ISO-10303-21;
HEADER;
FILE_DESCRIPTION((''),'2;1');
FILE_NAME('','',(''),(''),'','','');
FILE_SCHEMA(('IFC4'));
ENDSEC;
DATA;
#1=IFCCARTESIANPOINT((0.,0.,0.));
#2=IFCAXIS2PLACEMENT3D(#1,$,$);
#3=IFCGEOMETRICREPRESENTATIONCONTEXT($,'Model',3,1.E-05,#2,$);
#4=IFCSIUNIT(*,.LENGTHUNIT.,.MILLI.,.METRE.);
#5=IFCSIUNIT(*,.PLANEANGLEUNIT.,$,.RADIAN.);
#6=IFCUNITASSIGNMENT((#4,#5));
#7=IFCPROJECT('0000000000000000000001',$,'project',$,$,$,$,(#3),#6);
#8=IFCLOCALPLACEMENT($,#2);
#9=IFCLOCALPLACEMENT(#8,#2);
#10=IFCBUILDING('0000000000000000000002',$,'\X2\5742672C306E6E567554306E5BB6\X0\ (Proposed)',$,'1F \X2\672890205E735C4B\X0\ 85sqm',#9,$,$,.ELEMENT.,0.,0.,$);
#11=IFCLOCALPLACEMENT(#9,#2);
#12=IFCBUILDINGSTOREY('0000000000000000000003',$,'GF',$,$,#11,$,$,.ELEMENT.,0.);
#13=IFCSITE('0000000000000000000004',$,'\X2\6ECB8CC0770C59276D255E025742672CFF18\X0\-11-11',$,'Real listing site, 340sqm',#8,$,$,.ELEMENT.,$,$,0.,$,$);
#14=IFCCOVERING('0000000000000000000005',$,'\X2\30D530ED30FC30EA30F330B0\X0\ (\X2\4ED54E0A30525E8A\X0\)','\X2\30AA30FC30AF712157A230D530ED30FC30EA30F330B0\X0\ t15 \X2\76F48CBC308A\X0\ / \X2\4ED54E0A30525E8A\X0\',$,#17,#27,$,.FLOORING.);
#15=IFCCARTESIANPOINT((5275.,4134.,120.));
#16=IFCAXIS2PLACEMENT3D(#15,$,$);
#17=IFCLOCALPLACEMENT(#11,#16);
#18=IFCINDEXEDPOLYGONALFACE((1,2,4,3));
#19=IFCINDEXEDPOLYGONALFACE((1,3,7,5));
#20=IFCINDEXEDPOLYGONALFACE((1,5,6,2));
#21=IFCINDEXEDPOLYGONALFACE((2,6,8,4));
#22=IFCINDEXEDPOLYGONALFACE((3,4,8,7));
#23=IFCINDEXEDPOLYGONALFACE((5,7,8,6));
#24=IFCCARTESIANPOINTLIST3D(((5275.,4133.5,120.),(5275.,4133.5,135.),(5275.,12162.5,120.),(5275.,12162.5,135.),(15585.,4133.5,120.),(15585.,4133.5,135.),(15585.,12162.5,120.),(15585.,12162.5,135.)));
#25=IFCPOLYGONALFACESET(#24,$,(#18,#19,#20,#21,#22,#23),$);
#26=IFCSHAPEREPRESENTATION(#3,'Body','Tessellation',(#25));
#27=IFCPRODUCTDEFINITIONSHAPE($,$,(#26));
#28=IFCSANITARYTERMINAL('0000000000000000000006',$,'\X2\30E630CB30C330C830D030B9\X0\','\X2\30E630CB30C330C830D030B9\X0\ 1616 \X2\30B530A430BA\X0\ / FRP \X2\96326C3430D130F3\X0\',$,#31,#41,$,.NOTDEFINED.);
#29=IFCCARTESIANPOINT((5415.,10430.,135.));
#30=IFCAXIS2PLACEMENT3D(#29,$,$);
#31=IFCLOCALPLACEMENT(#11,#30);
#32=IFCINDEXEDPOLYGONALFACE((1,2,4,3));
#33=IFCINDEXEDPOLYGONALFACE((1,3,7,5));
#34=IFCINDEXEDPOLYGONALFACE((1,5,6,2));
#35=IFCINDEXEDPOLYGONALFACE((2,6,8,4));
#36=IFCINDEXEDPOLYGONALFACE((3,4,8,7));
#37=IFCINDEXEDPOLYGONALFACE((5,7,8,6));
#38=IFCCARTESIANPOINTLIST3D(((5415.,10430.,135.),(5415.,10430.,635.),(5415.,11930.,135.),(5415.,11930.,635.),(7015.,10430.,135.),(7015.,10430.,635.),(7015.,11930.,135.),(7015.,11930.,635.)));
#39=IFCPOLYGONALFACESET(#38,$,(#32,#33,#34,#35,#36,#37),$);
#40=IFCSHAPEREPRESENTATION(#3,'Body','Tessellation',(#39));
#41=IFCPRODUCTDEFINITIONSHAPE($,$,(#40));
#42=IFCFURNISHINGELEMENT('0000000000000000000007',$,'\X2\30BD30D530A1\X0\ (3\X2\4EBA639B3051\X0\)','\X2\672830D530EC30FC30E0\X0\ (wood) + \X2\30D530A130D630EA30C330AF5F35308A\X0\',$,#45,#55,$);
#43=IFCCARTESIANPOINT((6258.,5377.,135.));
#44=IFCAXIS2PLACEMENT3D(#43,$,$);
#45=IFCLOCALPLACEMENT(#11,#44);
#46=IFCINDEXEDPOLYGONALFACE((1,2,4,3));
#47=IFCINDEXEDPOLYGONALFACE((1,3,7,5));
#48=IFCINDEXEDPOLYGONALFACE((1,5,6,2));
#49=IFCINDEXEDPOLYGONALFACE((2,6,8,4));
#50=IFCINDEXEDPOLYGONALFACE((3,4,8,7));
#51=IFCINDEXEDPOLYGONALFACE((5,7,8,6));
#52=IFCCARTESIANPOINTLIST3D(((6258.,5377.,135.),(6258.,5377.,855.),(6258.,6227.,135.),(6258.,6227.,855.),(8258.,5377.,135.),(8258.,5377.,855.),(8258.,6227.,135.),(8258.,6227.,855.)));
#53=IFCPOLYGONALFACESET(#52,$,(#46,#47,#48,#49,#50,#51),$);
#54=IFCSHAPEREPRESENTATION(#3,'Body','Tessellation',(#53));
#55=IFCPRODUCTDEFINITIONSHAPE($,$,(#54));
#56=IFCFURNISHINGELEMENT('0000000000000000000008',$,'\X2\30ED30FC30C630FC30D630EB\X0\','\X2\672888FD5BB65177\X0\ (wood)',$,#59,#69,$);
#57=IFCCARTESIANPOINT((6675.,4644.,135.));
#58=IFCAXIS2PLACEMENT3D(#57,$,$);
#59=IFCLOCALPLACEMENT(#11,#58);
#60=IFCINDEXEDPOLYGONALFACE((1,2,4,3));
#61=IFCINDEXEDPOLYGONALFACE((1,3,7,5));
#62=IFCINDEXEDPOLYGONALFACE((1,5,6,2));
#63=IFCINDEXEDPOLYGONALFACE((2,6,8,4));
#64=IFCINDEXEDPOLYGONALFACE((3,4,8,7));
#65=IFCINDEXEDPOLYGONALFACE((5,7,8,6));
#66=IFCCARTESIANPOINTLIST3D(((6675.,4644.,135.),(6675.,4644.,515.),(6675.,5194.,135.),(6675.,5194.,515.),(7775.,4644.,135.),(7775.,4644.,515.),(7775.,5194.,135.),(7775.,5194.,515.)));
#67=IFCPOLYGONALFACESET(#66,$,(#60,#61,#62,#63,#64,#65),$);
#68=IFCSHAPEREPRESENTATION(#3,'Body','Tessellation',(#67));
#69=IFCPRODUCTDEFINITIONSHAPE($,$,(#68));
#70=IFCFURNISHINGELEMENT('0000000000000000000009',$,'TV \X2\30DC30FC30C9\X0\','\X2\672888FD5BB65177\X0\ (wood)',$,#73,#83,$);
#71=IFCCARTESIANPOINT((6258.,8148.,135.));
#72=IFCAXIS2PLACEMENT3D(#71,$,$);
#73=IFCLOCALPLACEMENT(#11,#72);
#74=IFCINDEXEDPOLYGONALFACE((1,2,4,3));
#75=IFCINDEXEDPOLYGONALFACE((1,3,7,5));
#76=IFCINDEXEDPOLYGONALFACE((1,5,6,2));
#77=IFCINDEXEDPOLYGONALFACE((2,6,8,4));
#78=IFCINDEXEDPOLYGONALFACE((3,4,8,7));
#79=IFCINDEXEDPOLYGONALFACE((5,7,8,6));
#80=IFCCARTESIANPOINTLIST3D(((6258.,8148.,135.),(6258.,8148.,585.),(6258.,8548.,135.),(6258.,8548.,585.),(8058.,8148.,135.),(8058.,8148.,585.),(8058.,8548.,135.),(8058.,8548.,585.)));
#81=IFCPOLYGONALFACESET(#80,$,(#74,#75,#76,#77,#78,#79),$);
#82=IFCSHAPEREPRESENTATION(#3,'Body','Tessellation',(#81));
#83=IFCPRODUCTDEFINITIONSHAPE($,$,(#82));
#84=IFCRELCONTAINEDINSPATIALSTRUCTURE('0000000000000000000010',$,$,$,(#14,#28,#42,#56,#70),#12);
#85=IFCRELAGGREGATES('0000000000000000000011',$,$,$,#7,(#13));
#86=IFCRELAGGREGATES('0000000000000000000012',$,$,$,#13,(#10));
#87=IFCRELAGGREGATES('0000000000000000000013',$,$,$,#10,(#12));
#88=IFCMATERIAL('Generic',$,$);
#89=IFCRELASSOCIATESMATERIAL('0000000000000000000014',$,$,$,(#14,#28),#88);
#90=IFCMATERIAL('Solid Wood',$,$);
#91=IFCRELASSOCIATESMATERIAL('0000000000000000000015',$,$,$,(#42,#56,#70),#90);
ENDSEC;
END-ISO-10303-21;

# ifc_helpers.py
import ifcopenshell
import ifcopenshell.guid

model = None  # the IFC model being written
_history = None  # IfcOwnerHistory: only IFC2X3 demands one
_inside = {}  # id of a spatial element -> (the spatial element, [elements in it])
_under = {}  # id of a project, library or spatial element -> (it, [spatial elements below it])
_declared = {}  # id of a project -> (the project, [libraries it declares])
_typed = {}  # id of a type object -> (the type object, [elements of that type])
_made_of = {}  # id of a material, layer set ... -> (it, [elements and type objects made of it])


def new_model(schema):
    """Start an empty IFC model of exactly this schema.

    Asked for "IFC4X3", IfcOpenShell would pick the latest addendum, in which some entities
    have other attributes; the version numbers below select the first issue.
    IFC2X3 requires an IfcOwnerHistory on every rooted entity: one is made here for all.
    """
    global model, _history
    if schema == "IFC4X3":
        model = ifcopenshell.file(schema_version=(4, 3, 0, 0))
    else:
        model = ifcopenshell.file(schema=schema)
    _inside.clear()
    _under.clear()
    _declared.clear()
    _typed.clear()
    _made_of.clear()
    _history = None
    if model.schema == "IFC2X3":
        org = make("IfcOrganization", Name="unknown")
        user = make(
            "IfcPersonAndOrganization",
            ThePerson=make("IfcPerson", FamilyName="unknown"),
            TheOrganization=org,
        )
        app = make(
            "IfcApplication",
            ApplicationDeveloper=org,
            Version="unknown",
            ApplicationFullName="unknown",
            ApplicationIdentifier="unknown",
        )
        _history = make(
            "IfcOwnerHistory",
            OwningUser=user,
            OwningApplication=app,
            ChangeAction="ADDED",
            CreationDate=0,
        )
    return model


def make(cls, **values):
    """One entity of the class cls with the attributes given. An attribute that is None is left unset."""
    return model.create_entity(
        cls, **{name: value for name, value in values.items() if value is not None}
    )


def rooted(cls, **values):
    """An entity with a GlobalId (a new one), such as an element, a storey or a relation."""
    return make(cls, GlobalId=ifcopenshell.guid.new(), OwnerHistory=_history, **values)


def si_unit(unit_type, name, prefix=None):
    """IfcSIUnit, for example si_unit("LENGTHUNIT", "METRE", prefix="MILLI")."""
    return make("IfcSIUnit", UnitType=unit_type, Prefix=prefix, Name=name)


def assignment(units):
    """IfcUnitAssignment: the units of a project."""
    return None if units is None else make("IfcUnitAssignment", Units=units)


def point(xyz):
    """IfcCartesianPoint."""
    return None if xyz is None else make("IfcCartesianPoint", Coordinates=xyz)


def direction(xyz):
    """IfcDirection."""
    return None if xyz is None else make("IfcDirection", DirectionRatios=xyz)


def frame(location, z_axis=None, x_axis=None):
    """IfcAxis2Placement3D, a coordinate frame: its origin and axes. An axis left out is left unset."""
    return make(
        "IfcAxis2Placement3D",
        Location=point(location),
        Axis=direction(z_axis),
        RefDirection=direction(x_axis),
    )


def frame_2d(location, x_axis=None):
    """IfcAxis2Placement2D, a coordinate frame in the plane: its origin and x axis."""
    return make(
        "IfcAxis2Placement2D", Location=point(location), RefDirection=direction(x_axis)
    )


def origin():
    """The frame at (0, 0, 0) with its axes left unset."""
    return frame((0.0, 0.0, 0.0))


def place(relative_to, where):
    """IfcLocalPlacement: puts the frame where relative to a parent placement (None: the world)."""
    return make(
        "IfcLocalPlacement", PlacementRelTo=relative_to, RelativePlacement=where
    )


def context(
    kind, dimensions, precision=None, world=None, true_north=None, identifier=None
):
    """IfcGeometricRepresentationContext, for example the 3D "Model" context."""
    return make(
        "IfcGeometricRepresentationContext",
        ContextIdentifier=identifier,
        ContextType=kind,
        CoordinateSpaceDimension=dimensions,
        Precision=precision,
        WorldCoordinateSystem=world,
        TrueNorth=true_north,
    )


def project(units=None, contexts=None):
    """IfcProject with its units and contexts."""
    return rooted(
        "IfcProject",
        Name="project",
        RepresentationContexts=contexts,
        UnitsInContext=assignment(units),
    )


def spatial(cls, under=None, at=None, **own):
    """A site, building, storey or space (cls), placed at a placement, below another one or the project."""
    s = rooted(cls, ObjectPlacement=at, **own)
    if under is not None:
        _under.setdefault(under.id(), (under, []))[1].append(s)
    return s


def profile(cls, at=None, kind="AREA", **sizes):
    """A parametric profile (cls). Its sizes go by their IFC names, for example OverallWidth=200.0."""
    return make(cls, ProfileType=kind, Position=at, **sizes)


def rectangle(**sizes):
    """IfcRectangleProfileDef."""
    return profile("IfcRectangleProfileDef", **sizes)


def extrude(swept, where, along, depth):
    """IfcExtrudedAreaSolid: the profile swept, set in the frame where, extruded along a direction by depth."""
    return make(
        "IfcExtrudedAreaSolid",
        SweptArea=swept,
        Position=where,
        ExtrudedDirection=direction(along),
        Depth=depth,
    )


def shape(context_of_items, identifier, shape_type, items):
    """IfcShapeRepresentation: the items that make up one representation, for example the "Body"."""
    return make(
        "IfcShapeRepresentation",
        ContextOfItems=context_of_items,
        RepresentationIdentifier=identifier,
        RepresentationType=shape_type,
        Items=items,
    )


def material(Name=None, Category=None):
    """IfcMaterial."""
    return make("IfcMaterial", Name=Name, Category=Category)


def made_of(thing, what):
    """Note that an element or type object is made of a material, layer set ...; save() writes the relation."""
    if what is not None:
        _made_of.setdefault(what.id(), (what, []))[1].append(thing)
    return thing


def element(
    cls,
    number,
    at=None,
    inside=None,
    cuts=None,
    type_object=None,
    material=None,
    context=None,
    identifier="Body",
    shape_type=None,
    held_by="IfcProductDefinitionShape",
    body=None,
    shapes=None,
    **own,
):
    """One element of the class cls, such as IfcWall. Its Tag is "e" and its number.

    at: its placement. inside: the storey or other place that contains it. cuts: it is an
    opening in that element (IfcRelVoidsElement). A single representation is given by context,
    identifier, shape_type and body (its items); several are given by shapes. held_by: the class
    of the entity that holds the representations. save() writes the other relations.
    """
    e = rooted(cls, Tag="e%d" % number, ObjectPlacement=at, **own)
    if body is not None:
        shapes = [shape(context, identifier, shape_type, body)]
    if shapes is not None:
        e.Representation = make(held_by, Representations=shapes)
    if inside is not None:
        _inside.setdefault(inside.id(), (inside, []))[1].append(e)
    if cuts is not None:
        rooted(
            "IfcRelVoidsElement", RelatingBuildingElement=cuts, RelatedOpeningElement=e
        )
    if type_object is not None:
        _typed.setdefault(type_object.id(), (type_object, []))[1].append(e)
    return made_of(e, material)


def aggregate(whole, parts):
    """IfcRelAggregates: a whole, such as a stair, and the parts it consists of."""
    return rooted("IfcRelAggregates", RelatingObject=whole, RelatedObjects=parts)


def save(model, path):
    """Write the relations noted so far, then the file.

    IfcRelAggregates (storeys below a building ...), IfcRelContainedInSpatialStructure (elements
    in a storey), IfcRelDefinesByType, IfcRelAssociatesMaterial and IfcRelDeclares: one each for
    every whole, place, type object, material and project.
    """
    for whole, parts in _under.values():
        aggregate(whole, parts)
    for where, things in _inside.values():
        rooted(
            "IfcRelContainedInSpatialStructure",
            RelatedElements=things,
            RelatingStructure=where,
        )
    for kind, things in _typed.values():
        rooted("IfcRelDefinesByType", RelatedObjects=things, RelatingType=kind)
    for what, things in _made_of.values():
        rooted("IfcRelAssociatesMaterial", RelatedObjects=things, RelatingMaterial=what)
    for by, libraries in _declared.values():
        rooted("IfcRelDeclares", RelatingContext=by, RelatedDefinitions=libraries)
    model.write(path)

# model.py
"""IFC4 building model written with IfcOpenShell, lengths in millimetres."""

from ifc_helpers import new_model, si_unit, frame, frame_2d, origin, place, context, project, spatial, rectangle, extrude, material, element, save


model = new_model("IFC4")

# Units and contexts
model_context = context("Model", 3, precision=1e-05, world=origin())
ifc_project = project(units=[si_unit("LENGTHUNIT", "METRE", prefix="MILLI"), si_unit("PLANEANGLEUNIT", "RADIAN")], contexts=[model_context])

# Site, building, storey
site_placement = place(None, origin())
site = spatial("IfcSite", under=ifc_project, at=site_placement, Name="滋賀県大津市坂本８-11-11", ObjectType="Real listing site, 340sqm", CompositionType="ELEMENT", RefElevation=0.0)
building_placement = place(site_placement, origin())
building = spatial("IfcBuilding", under=site, at=building_placement, Name="坂本の湖畔の家 (Proposed)", ObjectType="1F 木造平屋 85sqm", CompositionType="ELEMENT", ElevationOfRefHeight=0.0, ElevationOfTerrain=0.0)
storey_placement = place(building_placement, origin())
storey = spatial("IfcBuildingStorey", under=building, at=storey_placement, Name="GF", CompositionType="ELEMENT", Elevation=0.0)

# Shared definitions
ifc_material_1 = material(Name="Solid Wood")

# Covering
ifc_material_2 = material(Name="Generic")
covering_placement = place(storey_placement, frame((5275.0, 4134.0, 120.0)))
element("IfcCovering", 1, at=covering_placement, inside=storey, material=ifc_material_2, Name="フローリング (仕上げ床)", Description="オーク無垢フローリング t15 直貼り / 仕上げ床", PredefinedType="FLOORING", context=model_context, shape_type="SweptSolid", body=[
    extrude(rectangle(XDim=10310.0, YDim=8029.0, at=frame_2d((5155.0, 4014.0))), frame((5275.0, 4134.0, 120.0)), (0.0, 0.0, 1.0), 15.0),
])

# Sanitary terminal
sanitary_terminal_placement = place(storey_placement, frame((5415.0, 10430.0, 135.0)))
element("IfcSanitaryTerminal", 2, at=sanitary_terminal_placement, inside=storey, material=ifc_material_2, Name="ユニットバス", Description="ユニットバス 1616 サイズ / FRP 防水パン", PredefinedType="NOTDEFINED", context=model_context, shape_type="SweptSolid", body=[
    extrude(rectangle(XDim=1600.0, YDim=1500.0, at=frame_2d((800.0, 750.0))), frame((5415.0, 10430.0, 135.0)), (0.0, 0.0, 1.0), 500.0),
])

# Furnishing elements
furnishing_1_placement = place(storey_placement, frame((6258.0, 5377.0, 135.0)))
element("IfcFurnishingElement", 3, at=furnishing_1_placement, inside=storey, material=ifc_material_1, Name="ソファ (3人掛け)", Description="木フレーム (wood) + ファブリック張り", context=model_context, shape_type="SweptSolid", body=[
    extrude(rectangle(XDim=2000.0, YDim=850.0, at=frame_2d((1000.0, 425.0))), frame((6258.0, 5377.0, 135.0)), (0.0, 0.0, 1.0), 720.0),
])
furnishing_2_placement = place(storey_placement, frame((6675.0, 4644.0, 135.0)))
element("IfcFurnishingElement", 4, at=furnishing_2_placement, inside=storey, material=ifc_material_1, Name="ローテーブル", Description="木製家具 (wood)", context=model_context, shape_type="SweptSolid", body=[
    extrude(rectangle(XDim=1100.0, YDim=550.0, at=frame_2d((550.0, 275.0))), frame((6675.0, 4644.0, 135.0)), (0.0, 0.0, 1.0), 380.0),
])
furnishing_3_placement = place(storey_placement, frame((6258.0, 8148.0, 135.0)))
element("IfcFurnishingElement", 5, at=furnishing_3_placement, inside=storey, material=ifc_material_1, Name="TV ボード", Description="木製家具 (wood)", context=model_context, shape_type="SweptSolid", body=[
    extrude(rectangle(XDim=1800.0, YDim=400.0, at=frame_2d((900.0, 200.0))), frame((6258.0, 8148.0, 135.0)), (0.0, 0.0, 1.0), 450.0),
])

save(model, "model.ifc")
